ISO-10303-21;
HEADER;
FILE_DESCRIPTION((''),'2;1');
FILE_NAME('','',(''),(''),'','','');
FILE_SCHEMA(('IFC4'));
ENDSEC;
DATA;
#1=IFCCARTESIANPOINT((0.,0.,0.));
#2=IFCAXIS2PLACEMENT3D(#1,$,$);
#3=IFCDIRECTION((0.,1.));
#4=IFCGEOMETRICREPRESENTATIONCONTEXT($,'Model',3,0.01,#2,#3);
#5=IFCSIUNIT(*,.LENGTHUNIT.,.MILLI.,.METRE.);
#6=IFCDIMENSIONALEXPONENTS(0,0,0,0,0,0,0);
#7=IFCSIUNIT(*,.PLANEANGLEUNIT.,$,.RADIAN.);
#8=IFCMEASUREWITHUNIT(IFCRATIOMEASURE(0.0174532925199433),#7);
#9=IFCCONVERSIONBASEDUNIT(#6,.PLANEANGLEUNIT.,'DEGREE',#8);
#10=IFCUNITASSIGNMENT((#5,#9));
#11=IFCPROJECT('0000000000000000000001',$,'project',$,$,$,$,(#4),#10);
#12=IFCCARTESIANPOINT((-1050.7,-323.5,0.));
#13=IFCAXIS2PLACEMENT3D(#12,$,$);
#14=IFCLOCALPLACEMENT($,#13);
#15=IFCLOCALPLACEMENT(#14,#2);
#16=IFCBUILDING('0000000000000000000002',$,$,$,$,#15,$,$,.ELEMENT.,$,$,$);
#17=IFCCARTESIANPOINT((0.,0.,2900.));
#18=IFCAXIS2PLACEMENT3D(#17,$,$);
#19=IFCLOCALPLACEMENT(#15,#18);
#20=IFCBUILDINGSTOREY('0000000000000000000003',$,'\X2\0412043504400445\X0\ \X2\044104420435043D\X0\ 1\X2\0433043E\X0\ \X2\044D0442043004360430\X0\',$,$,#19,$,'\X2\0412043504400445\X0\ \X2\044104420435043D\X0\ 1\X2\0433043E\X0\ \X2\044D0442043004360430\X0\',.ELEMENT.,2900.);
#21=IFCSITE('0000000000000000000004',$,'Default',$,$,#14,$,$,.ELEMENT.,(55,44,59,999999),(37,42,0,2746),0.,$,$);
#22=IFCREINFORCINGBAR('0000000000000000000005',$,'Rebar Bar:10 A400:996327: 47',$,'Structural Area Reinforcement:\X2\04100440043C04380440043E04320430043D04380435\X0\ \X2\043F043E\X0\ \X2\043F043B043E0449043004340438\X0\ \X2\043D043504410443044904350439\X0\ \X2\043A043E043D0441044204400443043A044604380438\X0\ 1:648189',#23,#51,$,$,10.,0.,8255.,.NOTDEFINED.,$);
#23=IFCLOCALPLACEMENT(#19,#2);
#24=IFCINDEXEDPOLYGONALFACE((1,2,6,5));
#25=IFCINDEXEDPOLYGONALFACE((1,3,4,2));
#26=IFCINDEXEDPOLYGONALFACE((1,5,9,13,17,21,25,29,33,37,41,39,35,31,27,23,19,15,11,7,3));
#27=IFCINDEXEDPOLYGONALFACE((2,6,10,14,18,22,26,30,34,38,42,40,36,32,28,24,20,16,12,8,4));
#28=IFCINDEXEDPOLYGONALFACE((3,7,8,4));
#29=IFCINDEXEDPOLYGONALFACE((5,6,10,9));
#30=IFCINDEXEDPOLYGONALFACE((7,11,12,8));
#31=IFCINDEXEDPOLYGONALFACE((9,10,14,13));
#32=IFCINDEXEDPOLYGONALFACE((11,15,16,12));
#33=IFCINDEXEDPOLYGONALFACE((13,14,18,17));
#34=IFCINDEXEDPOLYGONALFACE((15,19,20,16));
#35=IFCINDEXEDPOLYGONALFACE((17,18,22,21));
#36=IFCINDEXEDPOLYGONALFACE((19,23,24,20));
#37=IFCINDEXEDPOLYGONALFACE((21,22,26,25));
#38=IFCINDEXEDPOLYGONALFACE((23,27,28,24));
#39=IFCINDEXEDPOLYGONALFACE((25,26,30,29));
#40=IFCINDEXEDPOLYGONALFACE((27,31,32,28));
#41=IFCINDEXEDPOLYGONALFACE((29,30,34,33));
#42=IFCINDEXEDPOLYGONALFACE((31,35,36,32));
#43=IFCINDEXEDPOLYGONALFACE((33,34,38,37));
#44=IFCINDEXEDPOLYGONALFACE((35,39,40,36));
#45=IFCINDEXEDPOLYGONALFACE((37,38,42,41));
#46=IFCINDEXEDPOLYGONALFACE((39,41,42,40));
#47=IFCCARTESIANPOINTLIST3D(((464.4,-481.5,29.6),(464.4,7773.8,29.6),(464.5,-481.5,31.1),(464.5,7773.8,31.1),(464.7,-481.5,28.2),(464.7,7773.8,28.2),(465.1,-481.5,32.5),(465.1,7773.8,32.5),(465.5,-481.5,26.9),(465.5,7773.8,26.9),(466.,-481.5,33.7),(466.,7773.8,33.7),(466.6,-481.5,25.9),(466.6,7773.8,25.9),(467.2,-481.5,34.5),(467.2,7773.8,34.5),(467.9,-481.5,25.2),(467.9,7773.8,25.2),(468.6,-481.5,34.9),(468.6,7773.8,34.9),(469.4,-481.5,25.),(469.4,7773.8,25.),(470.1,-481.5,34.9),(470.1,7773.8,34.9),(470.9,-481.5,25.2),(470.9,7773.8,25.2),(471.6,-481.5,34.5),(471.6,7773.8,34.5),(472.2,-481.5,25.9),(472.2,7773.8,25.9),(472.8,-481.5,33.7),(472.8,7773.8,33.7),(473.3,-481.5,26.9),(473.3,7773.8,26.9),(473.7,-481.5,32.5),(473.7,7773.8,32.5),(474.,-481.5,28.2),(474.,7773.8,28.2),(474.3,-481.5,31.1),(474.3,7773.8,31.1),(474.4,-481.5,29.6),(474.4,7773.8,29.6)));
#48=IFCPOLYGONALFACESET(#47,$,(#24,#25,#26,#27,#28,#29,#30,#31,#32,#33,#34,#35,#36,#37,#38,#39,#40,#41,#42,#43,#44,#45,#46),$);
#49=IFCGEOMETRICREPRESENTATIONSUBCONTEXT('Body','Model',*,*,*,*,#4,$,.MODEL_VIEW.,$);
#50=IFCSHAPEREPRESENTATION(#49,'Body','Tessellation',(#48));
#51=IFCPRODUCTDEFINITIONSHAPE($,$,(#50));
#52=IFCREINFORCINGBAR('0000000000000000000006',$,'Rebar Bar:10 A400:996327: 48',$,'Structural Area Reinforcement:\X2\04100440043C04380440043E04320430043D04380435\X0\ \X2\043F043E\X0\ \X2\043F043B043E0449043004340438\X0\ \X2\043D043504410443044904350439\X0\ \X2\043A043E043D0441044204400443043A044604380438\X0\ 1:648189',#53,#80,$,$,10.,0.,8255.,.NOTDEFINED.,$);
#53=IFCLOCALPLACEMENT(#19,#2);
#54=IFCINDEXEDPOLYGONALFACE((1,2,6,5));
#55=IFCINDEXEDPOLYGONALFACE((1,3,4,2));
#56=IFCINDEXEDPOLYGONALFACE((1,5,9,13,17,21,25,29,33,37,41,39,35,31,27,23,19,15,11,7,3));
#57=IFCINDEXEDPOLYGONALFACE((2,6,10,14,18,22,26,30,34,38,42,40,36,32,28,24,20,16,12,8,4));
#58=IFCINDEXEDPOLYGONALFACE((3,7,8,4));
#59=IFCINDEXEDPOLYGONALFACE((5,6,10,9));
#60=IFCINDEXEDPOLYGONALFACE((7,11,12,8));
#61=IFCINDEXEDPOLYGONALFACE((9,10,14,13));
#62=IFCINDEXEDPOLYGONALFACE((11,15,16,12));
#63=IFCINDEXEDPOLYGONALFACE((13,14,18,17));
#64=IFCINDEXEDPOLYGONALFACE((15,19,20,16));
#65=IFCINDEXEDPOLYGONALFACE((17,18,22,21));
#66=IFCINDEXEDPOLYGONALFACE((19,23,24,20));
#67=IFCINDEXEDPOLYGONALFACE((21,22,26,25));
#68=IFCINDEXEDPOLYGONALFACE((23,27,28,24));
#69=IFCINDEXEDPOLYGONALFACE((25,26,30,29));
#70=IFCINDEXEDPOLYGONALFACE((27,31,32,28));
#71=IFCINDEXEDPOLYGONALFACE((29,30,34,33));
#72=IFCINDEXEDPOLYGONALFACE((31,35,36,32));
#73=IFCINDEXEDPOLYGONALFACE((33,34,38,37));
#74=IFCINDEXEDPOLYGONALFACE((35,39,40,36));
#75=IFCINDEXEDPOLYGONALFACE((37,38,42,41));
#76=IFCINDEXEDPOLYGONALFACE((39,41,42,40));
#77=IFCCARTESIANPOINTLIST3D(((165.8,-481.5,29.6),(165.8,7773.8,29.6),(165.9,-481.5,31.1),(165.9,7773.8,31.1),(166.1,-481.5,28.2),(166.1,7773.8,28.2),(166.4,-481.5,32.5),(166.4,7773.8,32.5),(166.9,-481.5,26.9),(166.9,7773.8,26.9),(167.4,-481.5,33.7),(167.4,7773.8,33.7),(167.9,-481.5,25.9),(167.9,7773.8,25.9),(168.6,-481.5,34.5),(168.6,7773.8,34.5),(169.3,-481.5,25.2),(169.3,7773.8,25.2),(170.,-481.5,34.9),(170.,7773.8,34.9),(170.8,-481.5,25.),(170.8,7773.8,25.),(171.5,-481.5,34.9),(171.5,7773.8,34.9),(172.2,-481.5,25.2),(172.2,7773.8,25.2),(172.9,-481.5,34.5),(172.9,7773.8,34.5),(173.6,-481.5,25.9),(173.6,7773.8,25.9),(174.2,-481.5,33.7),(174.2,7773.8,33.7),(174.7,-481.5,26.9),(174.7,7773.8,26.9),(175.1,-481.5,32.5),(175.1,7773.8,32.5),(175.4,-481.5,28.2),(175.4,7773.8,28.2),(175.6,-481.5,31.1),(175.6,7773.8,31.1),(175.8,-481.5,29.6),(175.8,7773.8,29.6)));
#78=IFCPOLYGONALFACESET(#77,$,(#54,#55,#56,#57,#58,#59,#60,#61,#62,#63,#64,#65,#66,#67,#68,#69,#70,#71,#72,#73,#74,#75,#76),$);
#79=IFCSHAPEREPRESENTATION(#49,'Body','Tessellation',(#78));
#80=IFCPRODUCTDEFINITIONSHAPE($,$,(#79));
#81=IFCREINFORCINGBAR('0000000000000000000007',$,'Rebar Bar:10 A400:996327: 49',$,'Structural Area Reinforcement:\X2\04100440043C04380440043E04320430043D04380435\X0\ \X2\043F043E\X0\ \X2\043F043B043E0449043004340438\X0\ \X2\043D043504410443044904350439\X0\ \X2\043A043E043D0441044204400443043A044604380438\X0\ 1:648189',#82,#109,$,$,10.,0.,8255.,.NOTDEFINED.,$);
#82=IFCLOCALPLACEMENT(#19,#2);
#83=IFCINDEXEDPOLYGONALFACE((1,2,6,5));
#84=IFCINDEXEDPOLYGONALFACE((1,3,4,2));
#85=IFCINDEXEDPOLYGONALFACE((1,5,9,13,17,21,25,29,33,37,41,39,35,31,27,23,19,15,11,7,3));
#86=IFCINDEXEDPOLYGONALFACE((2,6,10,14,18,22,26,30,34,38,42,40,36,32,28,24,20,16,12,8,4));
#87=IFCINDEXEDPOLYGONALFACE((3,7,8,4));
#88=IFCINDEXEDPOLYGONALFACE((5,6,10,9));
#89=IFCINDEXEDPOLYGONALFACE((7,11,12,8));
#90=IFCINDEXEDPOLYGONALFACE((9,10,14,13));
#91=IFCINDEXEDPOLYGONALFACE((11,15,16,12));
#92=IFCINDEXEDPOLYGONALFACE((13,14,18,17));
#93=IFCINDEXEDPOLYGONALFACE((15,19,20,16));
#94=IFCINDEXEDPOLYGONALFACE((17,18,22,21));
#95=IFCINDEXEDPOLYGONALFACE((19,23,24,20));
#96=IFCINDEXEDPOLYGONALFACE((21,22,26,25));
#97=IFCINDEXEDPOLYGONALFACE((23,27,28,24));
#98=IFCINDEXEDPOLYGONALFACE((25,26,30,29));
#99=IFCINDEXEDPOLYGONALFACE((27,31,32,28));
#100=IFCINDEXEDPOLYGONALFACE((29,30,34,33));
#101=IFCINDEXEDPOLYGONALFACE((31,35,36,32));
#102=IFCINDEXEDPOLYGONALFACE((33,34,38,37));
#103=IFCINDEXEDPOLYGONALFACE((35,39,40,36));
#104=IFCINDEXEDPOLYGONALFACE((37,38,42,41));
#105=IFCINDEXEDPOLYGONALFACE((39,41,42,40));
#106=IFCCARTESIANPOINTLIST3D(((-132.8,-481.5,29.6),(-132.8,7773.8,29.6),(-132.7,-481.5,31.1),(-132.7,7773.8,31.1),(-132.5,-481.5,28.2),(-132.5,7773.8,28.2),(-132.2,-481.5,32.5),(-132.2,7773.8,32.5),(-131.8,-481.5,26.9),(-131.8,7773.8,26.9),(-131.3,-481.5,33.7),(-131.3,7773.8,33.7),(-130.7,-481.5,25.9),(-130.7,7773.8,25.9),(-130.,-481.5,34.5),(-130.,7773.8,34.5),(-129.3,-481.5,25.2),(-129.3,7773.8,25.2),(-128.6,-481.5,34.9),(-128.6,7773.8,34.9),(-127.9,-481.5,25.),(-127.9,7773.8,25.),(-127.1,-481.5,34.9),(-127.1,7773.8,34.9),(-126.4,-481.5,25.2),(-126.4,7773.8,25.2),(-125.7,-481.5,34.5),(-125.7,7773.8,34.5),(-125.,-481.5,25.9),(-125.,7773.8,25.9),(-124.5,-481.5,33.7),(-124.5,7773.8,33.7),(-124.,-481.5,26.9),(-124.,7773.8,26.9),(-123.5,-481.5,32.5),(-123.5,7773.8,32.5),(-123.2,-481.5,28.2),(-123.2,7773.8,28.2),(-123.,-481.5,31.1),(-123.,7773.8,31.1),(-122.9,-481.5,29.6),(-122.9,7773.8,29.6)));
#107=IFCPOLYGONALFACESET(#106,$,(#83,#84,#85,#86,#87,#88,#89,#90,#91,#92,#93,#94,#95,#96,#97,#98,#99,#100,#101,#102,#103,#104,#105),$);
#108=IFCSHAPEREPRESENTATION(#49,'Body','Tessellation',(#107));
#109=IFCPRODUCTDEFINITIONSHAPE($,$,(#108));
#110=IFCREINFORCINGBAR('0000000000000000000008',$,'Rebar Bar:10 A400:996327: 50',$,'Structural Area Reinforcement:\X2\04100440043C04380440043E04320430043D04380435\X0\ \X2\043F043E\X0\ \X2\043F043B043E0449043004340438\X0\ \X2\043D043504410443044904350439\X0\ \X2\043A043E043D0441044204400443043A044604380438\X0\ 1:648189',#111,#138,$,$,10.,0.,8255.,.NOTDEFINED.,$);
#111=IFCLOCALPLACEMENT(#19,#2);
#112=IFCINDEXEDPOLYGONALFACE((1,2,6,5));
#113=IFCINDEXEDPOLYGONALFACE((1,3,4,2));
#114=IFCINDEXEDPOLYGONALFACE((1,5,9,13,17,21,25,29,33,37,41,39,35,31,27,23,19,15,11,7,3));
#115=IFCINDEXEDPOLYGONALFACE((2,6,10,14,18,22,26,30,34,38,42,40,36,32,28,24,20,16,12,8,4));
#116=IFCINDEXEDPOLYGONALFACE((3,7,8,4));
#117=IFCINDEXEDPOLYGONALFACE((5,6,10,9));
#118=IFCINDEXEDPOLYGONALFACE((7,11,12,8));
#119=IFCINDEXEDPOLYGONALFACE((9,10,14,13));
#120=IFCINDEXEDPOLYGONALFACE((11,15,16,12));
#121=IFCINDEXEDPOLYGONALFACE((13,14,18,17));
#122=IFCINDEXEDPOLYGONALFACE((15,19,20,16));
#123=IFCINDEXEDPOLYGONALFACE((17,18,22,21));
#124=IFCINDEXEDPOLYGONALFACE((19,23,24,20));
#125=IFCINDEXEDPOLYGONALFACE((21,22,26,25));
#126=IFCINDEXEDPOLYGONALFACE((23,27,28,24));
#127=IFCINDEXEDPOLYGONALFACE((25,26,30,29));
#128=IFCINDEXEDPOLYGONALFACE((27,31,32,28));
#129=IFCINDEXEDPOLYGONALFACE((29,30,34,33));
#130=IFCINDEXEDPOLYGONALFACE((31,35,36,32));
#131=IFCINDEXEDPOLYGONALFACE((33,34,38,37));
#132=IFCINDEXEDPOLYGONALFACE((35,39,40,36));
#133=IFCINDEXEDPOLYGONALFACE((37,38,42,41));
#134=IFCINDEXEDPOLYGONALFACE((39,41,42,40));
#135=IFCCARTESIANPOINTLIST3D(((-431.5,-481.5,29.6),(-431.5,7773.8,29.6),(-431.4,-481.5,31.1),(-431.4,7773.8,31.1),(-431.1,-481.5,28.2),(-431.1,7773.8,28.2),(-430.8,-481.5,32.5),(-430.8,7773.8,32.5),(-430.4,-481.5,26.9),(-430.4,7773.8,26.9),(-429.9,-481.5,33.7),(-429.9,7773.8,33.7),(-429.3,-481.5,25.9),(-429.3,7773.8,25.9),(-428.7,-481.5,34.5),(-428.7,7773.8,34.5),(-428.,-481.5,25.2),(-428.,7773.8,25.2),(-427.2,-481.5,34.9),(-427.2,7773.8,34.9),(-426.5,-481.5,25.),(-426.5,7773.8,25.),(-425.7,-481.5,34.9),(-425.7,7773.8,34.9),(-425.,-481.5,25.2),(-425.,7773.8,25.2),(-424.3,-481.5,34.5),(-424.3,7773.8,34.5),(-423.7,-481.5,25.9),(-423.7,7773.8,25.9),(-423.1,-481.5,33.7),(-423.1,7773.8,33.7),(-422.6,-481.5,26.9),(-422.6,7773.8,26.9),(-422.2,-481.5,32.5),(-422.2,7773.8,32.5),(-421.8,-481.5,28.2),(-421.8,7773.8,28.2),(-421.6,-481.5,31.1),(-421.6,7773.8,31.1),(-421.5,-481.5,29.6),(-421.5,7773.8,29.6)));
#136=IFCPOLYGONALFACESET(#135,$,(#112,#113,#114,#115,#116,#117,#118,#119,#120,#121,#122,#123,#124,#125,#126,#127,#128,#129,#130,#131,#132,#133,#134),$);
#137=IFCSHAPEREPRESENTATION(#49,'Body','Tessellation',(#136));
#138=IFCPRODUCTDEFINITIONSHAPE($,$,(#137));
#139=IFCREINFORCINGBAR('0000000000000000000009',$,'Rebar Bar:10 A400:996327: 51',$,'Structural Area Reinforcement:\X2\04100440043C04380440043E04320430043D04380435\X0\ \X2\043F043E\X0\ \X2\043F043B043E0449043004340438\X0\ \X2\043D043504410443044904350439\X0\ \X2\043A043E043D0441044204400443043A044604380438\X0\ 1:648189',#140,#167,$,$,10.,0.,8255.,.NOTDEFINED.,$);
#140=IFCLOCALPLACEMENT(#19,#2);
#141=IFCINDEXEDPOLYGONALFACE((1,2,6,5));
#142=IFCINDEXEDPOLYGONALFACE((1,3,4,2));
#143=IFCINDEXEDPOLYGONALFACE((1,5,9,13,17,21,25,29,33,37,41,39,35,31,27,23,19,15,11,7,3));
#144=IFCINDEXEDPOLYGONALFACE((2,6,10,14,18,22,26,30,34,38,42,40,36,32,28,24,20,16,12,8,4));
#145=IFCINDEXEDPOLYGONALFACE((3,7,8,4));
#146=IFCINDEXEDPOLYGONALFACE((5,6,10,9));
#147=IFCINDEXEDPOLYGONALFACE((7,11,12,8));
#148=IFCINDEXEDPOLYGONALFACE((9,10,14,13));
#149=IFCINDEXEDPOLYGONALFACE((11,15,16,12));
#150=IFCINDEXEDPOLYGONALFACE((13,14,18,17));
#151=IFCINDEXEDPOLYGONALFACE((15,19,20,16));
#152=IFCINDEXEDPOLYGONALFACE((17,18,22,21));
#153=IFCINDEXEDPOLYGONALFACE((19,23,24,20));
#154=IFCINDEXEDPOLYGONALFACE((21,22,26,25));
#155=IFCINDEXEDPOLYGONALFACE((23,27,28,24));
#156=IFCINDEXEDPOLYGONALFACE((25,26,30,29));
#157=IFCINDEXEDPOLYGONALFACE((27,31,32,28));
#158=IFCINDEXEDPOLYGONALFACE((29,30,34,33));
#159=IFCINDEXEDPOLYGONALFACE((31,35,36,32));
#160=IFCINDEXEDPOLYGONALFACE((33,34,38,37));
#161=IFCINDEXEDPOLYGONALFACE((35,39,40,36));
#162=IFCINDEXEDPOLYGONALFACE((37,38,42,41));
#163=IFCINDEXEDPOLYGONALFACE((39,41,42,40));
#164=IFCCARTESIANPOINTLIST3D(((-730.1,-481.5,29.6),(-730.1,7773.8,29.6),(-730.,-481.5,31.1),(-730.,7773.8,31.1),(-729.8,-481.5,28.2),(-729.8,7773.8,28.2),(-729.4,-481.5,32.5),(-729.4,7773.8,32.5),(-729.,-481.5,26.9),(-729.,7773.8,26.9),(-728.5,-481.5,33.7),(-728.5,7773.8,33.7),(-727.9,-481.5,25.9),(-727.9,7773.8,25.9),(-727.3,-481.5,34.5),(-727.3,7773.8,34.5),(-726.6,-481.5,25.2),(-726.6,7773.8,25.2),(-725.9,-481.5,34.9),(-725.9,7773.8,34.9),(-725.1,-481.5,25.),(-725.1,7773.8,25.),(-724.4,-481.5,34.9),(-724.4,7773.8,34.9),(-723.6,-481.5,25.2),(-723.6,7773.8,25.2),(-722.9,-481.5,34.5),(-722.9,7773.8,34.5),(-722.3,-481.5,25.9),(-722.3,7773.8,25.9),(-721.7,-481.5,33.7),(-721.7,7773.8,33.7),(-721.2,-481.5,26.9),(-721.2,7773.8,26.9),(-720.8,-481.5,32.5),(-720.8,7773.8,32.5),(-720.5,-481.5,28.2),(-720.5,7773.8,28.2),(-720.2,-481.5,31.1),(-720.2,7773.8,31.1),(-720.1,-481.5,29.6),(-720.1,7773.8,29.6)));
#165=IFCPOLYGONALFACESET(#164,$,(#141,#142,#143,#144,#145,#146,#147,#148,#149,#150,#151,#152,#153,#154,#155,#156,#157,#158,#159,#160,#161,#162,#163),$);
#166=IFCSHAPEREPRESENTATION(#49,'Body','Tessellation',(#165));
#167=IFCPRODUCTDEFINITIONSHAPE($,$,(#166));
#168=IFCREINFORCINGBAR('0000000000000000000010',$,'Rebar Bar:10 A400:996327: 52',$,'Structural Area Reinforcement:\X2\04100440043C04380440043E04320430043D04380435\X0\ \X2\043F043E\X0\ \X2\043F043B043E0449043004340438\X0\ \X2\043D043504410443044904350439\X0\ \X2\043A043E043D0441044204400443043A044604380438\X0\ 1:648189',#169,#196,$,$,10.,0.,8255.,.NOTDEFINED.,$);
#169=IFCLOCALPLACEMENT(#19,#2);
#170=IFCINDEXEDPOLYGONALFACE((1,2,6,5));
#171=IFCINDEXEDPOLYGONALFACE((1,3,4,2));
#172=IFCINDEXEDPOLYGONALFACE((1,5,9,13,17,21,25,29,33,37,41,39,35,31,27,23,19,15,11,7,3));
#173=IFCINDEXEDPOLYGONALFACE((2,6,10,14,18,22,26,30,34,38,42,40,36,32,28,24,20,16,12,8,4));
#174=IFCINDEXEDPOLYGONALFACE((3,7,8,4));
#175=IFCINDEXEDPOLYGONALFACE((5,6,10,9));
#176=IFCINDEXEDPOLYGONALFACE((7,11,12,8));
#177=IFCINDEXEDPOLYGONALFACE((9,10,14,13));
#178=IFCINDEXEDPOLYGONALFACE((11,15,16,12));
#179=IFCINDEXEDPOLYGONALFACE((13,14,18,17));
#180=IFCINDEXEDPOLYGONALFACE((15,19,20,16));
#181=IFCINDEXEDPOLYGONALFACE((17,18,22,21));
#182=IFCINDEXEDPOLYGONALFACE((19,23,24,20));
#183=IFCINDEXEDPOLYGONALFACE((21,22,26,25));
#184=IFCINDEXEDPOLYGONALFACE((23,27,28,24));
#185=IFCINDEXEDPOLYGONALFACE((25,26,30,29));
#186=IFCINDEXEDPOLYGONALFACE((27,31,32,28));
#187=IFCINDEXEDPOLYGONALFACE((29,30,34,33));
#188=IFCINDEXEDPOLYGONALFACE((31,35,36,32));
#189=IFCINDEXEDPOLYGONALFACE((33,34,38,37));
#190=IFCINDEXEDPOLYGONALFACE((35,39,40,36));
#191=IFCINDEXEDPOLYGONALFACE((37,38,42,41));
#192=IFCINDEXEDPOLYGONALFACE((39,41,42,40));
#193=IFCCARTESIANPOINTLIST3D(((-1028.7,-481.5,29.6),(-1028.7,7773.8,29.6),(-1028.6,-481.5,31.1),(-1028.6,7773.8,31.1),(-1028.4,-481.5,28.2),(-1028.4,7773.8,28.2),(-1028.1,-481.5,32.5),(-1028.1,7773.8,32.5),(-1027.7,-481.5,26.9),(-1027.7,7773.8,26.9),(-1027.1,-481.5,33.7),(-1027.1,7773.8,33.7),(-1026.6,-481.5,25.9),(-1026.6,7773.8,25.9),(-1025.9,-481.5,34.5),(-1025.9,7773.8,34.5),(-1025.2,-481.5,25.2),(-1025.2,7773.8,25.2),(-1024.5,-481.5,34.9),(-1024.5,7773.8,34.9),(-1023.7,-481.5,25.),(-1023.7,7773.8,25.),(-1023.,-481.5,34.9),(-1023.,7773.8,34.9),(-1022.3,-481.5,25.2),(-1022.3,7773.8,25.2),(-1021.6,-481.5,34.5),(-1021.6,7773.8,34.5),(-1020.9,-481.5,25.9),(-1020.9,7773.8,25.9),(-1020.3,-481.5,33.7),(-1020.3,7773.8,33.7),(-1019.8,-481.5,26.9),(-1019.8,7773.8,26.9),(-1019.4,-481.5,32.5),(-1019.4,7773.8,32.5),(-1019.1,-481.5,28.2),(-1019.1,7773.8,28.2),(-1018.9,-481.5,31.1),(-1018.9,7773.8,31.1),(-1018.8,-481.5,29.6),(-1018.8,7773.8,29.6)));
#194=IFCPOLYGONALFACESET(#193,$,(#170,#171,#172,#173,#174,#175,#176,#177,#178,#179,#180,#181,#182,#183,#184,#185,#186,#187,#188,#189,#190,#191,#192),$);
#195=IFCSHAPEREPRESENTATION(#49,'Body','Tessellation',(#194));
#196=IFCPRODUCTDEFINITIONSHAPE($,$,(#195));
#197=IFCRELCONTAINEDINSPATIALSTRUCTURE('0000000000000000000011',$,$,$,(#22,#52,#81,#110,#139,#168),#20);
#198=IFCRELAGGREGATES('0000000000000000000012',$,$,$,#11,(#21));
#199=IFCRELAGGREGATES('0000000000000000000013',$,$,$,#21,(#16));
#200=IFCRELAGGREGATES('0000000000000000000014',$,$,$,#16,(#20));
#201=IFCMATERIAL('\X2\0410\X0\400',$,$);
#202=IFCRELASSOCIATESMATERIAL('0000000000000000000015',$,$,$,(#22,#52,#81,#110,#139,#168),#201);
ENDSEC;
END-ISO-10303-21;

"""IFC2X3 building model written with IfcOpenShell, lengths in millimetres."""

from ifc_helpers import new_model, entity, si_unit, converted_unit, direction, frame, origin, place, context, subcontext, project, spatial, material, element, save


model = new_model("IFC2X3")

# Units and contexts
model_context = context("Model", 3, precision=0.01, world=origin(), true_north=direction((0.0, 1.0)))
body_context = subcontext(model_context, "Body", "Model", "MODEL_VIEW")
ifc_project = project(units=[si_unit("LENGTHUNIT", "METRE", prefix="MILLI"), converted_unit("PLANEANGLEUNIT", "DEGREE", entity("IfcRatioMeasure", 0.0174532925199433), si_unit("PLANEANGLEUNIT", "RADIAN"), dimensions=[0, 0, 0, 0, 0, 0, 0])], contexts=[model_context])

# Site, building, storey
site_placement = place(None, frame((-1050.7, -323.5, 0.0)))
site = spatial("IfcSite", under=ifc_project, at=site_placement, Name="Default", CompositionType="ELEMENT", RefLatitude=(55, 44, 59, 999999), RefLongitude=(37, 42, 0, 2746), RefElevation=0.0)
building_placement = place(site_placement, origin())
building = spatial("IfcBuilding", under=site, at=building_placement, CompositionType="ELEMENT")
storey_placement = place(building_placement, frame((0.0, 0.0, 2900.0)))
storey = spatial("IfcBuildingStorey", under=building, at=storey_placement, Name="Верх стен 1го этажа", LongName="Верх стен 1го этажа", CompositionType="ELEMENT", Elevation=2900.0)

# Reinforcing bars
ifc_material = material(Name="А400")
reinforcing_bar_1_placement = place(storey_placement, origin())
element("IfcReinforcingBar", 1, at=reinforcing_bar_1_placement, inside=storey, material=ifc_material, Name="Rebar Bar:10 A400:996327: 47", ObjectType="Structural Area Reinforcement:Армирование по площади несущей конструкции 1:648189", BarLength=8255.0, BarRole="NOTDEFINED", CrossSectionArea=0.0, NominalDiameter=10.0, context=body_context, shape_type="AdvancedSweptSolid", body=[
    entity("IfcSweptDiskSolid", entity("IfcCompositeCurve", [entity("IfcCompositeCurveSegment", "CONTINUOUS", True, entity("IfcPolyline", [entity("IfcCartesianPoint", [469.4, 7773.8, 30.0]), entity("IfcCartesianPoint", [469.4, -481.5, 30.0])]))], False), 5.0, None, 0.0, 1.0),
])
reinforcing_bar_2_placement = place(storey_placement, origin())
element("IfcReinforcingBar", 2, at=reinforcing_bar_2_placement, inside=storey, material=ifc_material, Name="Rebar Bar:10 A400:996327: 48", ObjectType="Structural Area Reinforcement:Армирование по площади несущей конструкции 1:648189", BarLength=8255.0, BarRole="NOTDEFINED", CrossSectionArea=0.0, NominalDiameter=10.0, context=body_context, shape_type="AdvancedSweptSolid", body=[
    entity("IfcSweptDiskSolid", entity("IfcCompositeCurve", [entity("IfcCompositeCurveSegment", "CONTINUOUS", True, entity("IfcPolyline", [entity("IfcCartesianPoint", [170.8, 7773.8, 30.0]), entity("IfcCartesianPoint", [170.8, -481.5, 30.0])]))], False), 5.0, None, 0.0, 1.0),
])
reinforcing_bar_3_placement = place(storey_placement, origin())
element("IfcReinforcingBar", 3, at=reinforcing_bar_3_placement, inside=storey, material=ifc_material, Name="Rebar Bar:10 A400:996327: 49", ObjectType="Structural Area Reinforcement:Армирование по площади несущей конструкции 1:648189", BarLength=8255.0, BarRole="NOTDEFINED", CrossSectionArea=0.0, NominalDiameter=10.0, context=body_context, shape_type="AdvancedSweptSolid", body=[
    entity("IfcSweptDiskSolid", entity("IfcCompositeCurve", [entity("IfcCompositeCurveSegment", "CONTINUOUS", True, entity("IfcPolyline", [entity("IfcCartesianPoint", [-127.9, 7773.8, 30.0]), entity("IfcCartesianPoint", [-127.9, -481.5, 30.0])]))], False), 5.0, None, 0.0, 1.0),
])
reinforcing_bar_4_placement = place(storey_placement, origin())
element("IfcReinforcingBar", 4, at=reinforcing_bar_4_placement, inside=storey, material=ifc_material, Name="Rebar Bar:10 A400:996327: 50", ObjectType="Structural Area Reinforcement:Армирование по площади несущей конструкции 1:648189", BarLength=8255.0, BarRole="NOTDEFINED", CrossSectionArea=0.0, NominalDiameter=10.0, context=body_context, shape_type="AdvancedSweptSolid", body=[
    entity("IfcSweptDiskSolid", entity("IfcCompositeCurve", [entity("IfcCompositeCurveSegment", "CONTINUOUS", True, entity("IfcPolyline", [entity("IfcCartesianPoint", [-426.5, 7773.8, 30.0]), entity("IfcCartesianPoint", [-426.5, -481.5, 30.0])]))], False), 5.0, None, 0.0, 1.0),
])
reinforcing_bar_5_placement = place(storey_placement, origin())
element("IfcReinforcingBar", 5, at=reinforcing_bar_5_placement, inside=storey, material=ifc_material, Name="Rebar Bar:10 A400:996327: 51", ObjectType="Structural Area Reinforcement:Армирование по площади несущей конструкции 1:648189", BarLength=8255.0, BarRole="NOTDEFINED", CrossSectionArea=0.0, NominalDiameter=10.0, context=body_context, shape_type="AdvancedSweptSolid", body=[
    entity("IfcSweptDiskSolid", entity("IfcCompositeCurve", [entity("IfcCompositeCurveSegment", "CONTINUOUS", True, entity("IfcPolyline", [entity("IfcCartesianPoint", [-725.1, 7773.8, 30.0]), entity("IfcCartesianPoint", [-725.1, -481.5, 30.0])]))], False), 5.0, None, 0.0, 1.0),
])
reinforcing_bar_6_placement = place(storey_placement, origin())
element("IfcReinforcingBar", 6, at=reinforcing_bar_6_placement, inside=storey, material=ifc_material, Name="Rebar Bar:10 A400:996327: 52", ObjectType="Structural Area Reinforcement:Армирование по площади несущей конструкции 1:648189", BarLength=8255.0, BarRole="NOTDEFINED", CrossSectionArea=0.0, NominalDiameter=10.0, context=body_context, shape_type="AdvancedSweptSolid", body=[
    entity("IfcSweptDiskSolid", entity("IfcCompositeCurve", [entity("IfcCompositeCurveSegment", "CONTINUOUS", True, entity("IfcPolyline", [entity("IfcCartesianPoint", [-1023.7, 7773.8, 30.0]), entity("IfcCartesianPoint", [-1023.7, -481.5, 30.0])]))], False), 5.0, None, 0.0, 1.0),
])

save(model, "model.ifc")
